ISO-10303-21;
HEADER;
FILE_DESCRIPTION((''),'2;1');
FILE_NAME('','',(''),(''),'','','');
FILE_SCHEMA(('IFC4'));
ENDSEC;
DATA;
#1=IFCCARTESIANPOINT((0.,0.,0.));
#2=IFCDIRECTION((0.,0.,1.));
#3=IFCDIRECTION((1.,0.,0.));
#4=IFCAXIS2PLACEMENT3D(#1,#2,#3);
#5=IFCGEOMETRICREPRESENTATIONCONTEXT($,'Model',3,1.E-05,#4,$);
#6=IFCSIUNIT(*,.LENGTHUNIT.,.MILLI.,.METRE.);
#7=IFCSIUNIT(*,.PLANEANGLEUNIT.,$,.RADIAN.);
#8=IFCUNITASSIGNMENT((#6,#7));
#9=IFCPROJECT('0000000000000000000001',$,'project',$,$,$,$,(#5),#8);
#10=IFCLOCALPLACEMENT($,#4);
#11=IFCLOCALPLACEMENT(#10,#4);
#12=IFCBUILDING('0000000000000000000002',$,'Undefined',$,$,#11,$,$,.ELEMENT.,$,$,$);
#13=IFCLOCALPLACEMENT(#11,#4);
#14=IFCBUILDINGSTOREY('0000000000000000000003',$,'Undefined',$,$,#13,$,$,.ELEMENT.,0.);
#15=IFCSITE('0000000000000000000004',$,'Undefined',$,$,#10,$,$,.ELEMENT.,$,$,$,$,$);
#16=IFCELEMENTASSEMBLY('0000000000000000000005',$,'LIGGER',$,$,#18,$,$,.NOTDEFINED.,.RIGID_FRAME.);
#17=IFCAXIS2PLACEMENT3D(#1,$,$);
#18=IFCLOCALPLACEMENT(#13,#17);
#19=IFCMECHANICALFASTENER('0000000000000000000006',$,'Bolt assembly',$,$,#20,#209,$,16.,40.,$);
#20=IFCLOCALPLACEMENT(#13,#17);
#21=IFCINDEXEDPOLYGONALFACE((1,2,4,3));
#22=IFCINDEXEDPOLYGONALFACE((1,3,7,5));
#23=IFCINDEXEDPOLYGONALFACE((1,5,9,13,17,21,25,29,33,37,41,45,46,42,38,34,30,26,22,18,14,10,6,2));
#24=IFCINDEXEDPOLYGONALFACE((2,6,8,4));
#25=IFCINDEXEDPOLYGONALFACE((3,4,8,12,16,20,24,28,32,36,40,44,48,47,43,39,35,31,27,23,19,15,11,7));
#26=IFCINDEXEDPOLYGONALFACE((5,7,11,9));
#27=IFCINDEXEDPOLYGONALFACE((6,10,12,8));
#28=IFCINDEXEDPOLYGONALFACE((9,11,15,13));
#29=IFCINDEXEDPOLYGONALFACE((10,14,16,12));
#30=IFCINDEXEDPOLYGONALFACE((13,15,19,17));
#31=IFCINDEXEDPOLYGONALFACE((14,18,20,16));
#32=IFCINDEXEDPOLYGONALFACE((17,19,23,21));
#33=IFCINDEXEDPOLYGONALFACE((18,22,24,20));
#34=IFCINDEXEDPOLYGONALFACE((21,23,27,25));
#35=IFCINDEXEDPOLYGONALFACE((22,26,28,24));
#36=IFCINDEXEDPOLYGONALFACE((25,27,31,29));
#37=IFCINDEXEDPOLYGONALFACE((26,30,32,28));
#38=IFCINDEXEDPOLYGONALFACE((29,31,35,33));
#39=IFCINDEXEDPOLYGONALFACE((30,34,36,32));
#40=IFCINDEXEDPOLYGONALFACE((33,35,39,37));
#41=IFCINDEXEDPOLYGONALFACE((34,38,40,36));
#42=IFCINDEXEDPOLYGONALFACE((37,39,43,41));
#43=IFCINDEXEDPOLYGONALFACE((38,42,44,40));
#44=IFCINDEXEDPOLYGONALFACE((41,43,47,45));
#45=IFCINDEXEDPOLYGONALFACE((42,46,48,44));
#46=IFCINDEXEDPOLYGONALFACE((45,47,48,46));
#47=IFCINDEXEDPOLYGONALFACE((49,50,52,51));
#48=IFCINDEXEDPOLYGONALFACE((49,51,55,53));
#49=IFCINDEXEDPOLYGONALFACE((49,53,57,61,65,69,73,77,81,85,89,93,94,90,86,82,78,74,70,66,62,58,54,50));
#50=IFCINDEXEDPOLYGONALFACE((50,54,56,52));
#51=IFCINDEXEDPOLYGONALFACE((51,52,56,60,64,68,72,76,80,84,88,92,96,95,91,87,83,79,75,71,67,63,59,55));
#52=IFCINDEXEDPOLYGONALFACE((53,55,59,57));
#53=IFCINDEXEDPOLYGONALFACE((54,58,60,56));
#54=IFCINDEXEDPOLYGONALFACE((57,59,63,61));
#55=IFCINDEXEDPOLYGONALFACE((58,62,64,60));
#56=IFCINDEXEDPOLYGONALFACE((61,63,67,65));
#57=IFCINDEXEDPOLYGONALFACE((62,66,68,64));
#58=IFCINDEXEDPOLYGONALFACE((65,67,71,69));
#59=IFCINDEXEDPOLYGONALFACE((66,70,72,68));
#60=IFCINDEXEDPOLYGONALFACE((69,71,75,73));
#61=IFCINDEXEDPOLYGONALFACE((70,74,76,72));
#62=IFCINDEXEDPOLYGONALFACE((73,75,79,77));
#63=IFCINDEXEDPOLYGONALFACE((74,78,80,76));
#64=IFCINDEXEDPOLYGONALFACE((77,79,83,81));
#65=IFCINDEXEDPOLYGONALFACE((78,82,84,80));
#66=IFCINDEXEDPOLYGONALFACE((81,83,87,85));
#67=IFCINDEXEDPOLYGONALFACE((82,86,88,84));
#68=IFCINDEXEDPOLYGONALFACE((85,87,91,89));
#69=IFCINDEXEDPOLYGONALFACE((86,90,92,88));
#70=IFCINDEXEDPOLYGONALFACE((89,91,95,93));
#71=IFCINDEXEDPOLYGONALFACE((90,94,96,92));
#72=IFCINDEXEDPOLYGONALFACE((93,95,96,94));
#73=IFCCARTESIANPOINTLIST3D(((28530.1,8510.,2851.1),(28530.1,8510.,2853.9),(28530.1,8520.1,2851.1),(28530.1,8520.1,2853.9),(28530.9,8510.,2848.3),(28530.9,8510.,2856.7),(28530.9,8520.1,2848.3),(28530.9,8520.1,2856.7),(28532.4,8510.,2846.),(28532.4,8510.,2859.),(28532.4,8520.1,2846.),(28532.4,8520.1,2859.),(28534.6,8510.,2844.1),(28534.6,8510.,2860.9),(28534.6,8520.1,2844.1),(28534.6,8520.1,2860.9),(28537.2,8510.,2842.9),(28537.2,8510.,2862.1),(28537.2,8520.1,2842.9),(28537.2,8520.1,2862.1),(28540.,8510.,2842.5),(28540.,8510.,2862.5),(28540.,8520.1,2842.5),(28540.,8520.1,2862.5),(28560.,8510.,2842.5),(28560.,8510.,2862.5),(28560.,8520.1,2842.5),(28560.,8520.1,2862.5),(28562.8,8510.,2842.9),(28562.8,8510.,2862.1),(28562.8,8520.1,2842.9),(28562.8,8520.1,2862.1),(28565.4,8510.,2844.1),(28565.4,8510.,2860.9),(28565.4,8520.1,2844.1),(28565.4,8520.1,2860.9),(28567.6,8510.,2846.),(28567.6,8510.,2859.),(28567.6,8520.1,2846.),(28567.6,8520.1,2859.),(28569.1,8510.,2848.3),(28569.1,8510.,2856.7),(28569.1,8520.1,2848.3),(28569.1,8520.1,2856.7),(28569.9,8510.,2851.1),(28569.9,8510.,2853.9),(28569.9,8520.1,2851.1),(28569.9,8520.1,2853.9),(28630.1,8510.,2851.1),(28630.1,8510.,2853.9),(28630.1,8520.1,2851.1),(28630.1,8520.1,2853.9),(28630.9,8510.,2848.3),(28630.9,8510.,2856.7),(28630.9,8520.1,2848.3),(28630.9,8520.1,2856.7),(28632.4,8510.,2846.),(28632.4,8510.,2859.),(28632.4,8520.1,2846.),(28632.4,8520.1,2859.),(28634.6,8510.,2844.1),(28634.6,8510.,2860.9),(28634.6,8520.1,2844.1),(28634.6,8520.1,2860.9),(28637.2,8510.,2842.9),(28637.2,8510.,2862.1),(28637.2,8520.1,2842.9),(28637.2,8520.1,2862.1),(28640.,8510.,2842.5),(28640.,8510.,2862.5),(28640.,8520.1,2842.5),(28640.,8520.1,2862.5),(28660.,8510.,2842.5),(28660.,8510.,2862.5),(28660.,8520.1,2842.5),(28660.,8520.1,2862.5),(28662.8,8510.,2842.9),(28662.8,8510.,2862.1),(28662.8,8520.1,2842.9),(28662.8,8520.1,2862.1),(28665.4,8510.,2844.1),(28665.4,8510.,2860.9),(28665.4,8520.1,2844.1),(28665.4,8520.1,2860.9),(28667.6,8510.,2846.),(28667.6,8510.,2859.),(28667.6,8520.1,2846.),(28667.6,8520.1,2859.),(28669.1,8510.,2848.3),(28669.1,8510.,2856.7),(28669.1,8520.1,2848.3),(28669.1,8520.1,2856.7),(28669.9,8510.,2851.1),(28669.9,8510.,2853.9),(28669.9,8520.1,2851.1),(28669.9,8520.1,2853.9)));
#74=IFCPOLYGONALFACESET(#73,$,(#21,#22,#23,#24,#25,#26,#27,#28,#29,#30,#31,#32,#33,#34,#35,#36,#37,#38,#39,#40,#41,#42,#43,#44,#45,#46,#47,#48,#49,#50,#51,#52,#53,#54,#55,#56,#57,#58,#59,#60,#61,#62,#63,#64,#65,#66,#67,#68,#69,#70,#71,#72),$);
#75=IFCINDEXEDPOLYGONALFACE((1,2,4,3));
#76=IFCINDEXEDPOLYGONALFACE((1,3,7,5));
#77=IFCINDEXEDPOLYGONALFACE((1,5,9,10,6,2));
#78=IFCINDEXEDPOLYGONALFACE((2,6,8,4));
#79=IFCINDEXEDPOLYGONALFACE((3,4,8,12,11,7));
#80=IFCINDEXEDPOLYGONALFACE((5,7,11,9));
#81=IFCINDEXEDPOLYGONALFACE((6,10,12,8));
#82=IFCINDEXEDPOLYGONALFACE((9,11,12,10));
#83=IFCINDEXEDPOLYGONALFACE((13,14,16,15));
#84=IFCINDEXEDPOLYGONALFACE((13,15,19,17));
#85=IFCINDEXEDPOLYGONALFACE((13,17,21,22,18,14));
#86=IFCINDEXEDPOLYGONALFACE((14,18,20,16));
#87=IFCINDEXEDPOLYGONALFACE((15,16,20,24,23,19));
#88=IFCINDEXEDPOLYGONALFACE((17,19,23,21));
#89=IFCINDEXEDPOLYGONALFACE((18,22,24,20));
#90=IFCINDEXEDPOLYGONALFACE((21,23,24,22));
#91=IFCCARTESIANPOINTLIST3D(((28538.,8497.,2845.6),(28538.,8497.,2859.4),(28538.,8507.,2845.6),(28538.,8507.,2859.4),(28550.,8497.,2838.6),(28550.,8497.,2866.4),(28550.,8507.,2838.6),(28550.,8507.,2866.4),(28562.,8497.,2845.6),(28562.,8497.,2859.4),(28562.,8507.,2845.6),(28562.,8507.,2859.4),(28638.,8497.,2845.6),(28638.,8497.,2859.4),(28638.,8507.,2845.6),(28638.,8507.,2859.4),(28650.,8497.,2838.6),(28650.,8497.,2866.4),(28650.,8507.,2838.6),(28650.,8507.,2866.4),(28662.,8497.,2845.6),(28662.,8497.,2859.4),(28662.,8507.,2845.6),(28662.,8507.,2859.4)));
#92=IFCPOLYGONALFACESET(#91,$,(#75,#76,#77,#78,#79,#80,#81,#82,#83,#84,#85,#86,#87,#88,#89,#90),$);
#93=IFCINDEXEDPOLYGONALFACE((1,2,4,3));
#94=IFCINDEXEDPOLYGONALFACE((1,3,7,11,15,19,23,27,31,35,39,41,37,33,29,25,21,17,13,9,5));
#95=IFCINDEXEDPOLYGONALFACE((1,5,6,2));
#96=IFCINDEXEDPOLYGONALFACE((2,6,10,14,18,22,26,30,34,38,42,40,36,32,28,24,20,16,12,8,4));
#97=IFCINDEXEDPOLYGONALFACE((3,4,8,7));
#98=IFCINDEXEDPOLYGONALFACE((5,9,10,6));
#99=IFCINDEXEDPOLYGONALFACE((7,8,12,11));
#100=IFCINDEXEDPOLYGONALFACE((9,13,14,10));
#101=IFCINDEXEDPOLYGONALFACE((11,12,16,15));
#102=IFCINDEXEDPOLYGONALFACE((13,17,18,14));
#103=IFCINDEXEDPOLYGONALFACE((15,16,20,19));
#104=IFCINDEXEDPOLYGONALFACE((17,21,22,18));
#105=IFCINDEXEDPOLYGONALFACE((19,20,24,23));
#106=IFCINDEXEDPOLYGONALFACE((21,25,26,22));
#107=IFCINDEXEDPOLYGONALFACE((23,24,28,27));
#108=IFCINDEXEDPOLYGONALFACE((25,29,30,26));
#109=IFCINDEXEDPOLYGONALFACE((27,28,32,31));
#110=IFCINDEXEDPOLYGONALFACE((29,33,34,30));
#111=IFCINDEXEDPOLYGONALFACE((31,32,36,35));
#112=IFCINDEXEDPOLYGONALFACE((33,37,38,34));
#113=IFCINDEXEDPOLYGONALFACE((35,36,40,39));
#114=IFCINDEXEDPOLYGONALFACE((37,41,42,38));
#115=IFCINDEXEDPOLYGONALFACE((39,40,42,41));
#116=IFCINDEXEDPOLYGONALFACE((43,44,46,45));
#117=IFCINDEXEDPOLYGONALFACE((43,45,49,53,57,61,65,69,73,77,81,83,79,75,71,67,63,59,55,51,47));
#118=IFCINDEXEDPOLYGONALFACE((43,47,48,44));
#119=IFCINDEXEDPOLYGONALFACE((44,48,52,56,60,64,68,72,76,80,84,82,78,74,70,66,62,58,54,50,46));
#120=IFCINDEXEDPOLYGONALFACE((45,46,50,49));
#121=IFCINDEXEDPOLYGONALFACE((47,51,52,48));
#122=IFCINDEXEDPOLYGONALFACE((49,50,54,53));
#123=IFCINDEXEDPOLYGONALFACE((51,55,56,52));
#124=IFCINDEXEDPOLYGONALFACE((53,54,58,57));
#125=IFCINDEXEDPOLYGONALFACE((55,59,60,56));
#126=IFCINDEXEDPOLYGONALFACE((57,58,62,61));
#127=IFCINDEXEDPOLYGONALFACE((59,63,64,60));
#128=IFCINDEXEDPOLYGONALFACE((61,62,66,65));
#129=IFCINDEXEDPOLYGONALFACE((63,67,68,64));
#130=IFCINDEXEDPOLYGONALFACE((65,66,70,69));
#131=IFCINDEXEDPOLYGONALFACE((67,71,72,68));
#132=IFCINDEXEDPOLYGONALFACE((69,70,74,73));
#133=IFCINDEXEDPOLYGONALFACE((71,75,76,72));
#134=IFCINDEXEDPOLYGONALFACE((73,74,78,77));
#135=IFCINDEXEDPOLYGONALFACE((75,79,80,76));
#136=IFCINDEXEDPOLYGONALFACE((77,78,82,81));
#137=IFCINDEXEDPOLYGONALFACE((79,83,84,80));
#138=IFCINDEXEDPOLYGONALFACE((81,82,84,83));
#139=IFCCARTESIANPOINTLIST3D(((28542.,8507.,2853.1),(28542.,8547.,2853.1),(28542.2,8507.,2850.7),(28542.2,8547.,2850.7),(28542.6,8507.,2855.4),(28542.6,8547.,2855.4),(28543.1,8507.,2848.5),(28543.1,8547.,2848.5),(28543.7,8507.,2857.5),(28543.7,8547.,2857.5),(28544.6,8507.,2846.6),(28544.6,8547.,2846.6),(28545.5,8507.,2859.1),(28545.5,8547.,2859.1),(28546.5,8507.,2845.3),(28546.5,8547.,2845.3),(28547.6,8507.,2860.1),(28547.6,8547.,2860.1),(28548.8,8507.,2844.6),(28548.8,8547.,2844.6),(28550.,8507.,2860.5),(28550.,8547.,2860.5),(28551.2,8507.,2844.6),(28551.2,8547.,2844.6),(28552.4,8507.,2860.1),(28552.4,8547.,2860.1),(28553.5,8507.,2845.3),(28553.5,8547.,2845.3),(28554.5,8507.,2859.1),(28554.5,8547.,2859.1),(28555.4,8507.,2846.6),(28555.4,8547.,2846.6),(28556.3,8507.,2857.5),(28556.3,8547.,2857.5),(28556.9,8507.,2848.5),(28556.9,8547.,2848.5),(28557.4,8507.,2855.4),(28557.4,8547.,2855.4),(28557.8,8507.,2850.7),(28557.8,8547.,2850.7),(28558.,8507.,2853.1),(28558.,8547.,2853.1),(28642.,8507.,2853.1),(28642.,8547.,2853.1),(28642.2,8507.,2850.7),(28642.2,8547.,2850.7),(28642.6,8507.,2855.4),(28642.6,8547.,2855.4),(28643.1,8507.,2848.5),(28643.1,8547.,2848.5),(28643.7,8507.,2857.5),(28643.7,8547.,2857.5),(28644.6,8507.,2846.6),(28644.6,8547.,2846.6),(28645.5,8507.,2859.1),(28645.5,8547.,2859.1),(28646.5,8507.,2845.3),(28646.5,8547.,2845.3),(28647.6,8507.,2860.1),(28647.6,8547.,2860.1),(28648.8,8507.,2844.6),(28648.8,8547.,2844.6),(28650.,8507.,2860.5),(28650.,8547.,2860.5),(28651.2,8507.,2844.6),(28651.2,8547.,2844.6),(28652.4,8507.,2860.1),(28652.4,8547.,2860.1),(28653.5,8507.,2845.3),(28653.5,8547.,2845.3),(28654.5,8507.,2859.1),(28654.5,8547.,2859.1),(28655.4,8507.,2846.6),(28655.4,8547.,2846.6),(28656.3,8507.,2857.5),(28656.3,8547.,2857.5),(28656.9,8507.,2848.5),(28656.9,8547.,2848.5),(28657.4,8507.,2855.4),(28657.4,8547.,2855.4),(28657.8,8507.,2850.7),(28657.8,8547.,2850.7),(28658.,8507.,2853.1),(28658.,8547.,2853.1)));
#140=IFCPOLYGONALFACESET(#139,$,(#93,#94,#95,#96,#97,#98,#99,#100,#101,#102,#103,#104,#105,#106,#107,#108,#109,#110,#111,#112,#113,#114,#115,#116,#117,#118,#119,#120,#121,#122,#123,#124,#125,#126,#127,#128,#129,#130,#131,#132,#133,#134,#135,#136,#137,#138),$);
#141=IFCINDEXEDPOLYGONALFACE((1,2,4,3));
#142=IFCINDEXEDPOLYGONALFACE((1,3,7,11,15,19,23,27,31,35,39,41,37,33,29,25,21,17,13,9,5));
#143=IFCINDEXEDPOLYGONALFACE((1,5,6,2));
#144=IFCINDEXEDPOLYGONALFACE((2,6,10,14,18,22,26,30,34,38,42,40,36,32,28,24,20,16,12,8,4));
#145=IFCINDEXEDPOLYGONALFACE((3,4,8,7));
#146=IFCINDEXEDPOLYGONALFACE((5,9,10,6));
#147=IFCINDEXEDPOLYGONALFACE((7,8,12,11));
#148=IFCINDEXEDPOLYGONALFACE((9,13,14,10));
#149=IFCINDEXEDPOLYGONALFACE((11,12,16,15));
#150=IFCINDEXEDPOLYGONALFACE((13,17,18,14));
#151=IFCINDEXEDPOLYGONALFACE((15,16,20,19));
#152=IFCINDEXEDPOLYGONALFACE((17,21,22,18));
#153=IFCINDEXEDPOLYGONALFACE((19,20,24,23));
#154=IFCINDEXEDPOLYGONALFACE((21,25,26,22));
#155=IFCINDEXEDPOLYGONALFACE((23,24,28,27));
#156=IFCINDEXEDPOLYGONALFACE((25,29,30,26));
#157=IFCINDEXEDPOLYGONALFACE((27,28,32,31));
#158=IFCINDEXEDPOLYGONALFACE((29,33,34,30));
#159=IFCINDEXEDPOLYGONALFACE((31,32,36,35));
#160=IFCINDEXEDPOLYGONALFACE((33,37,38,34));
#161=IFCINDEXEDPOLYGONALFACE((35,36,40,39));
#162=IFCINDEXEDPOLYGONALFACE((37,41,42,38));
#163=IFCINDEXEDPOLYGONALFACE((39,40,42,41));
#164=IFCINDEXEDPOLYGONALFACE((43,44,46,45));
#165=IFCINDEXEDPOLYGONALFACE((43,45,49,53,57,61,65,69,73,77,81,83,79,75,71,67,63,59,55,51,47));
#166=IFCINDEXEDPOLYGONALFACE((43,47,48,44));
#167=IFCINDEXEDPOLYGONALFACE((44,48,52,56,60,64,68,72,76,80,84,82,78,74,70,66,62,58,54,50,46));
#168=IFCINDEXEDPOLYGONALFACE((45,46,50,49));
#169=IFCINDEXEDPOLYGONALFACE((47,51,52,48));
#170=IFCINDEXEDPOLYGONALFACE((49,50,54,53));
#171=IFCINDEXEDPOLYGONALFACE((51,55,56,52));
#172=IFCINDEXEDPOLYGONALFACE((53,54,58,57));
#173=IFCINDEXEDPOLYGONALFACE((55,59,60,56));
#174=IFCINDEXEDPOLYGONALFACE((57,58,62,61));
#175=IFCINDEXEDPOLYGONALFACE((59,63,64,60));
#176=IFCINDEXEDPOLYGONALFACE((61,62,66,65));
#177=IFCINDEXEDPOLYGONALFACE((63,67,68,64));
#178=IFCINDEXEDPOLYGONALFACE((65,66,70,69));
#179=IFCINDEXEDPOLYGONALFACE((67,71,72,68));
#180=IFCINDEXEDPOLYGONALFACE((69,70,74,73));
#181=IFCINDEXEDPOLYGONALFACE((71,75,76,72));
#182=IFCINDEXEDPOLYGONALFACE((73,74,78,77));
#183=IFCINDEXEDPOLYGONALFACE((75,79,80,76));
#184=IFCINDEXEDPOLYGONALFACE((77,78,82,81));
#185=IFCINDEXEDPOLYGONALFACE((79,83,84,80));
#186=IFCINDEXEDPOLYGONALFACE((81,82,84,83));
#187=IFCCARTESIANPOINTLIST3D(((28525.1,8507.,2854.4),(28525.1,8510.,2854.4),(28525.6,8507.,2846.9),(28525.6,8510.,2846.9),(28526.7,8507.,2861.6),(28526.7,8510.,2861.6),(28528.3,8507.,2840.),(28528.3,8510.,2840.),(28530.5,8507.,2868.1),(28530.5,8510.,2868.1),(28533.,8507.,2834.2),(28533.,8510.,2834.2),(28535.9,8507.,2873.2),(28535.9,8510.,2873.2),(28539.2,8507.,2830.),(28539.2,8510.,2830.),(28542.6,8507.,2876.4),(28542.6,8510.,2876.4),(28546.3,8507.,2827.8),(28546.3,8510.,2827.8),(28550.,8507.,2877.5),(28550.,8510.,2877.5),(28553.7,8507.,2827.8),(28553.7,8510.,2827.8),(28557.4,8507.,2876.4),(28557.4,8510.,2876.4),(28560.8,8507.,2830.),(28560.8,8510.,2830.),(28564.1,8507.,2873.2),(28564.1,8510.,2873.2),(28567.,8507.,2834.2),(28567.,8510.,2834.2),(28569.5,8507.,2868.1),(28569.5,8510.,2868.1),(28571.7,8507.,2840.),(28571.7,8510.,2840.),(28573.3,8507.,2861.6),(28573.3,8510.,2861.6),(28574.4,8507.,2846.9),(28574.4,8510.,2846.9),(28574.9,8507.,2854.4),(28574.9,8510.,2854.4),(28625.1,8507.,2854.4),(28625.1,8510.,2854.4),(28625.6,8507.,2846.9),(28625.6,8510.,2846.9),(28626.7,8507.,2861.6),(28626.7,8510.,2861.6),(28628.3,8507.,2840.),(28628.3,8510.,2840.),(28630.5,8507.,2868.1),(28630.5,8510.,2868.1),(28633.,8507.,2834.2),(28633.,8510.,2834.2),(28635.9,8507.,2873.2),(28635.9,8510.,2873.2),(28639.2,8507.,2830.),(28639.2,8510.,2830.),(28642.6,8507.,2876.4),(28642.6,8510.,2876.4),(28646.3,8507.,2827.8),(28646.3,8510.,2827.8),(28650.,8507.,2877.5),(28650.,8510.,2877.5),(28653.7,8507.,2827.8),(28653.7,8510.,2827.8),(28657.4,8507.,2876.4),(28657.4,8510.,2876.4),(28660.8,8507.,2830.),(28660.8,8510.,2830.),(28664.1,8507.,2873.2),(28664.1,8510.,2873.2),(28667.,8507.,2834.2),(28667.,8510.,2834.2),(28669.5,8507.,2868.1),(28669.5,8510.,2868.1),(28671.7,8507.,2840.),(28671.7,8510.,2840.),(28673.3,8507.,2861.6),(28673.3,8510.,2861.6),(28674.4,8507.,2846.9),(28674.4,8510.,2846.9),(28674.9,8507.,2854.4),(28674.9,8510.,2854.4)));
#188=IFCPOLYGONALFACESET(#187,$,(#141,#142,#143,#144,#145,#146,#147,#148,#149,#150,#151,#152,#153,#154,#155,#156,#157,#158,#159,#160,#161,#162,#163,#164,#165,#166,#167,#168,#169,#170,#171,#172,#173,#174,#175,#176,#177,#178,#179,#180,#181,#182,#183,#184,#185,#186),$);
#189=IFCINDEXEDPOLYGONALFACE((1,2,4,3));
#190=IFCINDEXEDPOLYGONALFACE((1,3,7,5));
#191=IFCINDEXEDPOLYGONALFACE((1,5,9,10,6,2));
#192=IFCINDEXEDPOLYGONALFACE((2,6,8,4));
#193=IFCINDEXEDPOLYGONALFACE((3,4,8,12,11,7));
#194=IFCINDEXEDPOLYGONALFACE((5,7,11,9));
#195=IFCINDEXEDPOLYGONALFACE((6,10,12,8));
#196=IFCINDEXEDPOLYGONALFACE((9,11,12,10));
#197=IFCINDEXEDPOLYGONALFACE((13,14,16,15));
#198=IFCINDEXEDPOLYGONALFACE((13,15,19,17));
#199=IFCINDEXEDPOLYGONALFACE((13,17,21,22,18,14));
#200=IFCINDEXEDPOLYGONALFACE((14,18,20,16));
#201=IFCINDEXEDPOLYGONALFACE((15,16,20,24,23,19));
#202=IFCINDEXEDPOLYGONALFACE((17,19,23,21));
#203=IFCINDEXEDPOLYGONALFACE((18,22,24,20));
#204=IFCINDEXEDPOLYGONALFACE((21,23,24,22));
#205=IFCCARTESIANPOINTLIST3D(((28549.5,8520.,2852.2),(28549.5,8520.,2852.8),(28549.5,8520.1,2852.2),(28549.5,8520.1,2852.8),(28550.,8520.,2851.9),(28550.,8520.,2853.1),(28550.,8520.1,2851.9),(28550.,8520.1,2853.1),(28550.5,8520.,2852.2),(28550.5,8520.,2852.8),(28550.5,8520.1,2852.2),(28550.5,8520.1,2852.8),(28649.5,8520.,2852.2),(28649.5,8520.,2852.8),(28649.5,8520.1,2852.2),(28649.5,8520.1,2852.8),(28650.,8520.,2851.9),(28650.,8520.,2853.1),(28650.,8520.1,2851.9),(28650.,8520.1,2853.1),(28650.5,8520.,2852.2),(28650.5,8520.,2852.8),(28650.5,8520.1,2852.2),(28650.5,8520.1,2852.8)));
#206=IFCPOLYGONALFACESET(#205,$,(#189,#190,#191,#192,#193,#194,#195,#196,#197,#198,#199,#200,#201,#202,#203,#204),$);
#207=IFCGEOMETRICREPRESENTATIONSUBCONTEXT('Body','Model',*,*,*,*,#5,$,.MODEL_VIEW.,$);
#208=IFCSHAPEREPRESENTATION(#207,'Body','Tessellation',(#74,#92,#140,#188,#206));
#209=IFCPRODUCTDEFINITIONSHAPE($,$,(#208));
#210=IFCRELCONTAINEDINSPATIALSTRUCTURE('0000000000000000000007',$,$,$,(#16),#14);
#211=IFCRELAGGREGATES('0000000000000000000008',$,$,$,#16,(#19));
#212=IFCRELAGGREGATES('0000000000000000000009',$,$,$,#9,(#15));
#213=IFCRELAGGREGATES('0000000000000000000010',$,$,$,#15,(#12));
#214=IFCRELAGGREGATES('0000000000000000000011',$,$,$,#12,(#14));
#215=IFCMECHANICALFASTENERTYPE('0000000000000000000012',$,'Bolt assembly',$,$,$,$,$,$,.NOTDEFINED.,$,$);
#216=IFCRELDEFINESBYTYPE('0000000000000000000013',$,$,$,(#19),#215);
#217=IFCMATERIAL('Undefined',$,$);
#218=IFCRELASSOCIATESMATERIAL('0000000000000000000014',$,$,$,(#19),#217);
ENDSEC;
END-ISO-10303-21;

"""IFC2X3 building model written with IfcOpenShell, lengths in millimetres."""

from ifc_helpers import new_model, si_unit, frame, frame_2d, origin_with_axes, origin_2d_with_axis, place, context, subcontext, project, spatial, polyline, circle_curve, parameter, trimmed, segment, composite_curve, circle, outline, extrude, source, transform, mapped, material, type_object, element, aggregate, save


model = new_model("IFC2X3")

# Units and contexts
model_context = context("Model", 3, precision=1e-05, world=origin_with_axes())
body_context = subcontext(model_context, "Body", "Model", "MODEL_VIEW")
ifc_project = project(units=[si_unit("LENGTHUNIT", "METRE", prefix="MILLI"), si_unit("PLANEANGLEUNIT", "RADIAN")], contexts=[model_context])

# Site, building, storey
site_placement = place(None, origin_with_axes())
site = spatial("IfcSite", under=ifc_project, at=site_placement, Name="Undefined", CompositionType="ELEMENT")
building_placement = place(site_placement, origin_with_axes())
building = spatial("IfcBuilding", under=site, at=building_placement, Name="Undefined", CompositionType="ELEMENT")
storey_placement = place(building_placement, origin_with_axes())
storey = spatial("IfcBuildingStorey", under=building, at=storey_placement, Name="Undefined", CompositionType="ELEMENT", Elevation=0.0)

# Element assembly
assembly_1_placement = place(storey_placement, origin_with_axes())
assembly_1 = element("IfcElementAssembly", 1, at=assembly_1_placement, inside=storey, Name="LIGGER", AssemblyPlace="NOTDEFINED", PredefinedType="RIGID_FRAME")

# Mechanical fastener
ifc_material_1 = material(Name="Undefined")
mechanical_fastener_type = type_object("IfcMechanicalFastenerType", Name="Bolt assembly")
shared_shape_1 = source(origin_with_axes(), body_context, "Body", "SweptSolid", [
    extrude(outline(composite_curve([segment(polyline([(10.0, 10.0), (10.0, -10.0)]), True, "CONTINUOUS"), segment(trimmed(circle_curve(frame_2d((0.0, -10.0), x_axis=(1.0, 0.0)), 10.0), [parameter(0.0)], [parameter(3.141593)], False, "PARAMETER"), True, "CONTINUOUS"), segment(polyline([(-10.0, -10.0), (-10.0, 10.0)]), True, "CONTINUOUS"), segment(trimmed(circle_curve(frame_2d((0.0, 10.0), x_axis=(-1.0, 0.0)), 10.0), [parameter(0.0)], [parameter(3.141593)], False, "PARAMETER"), True, "DISCONTINUOUS")], self_intersect=False)), frame((0.0, 30.0, 0.0), z_axis=(0.0, 1.0, 0.0), x_axis=(1.0, 0.0, 0.0)), (0.0, 0.0, 1.0), 10.1),
    extrude(outline(polyline([(13.9, 0.0), (6.9, 12.0), (-6.9, 12.0), (-13.9, 0.0), (-6.9, -12.0), (6.9, -12.0), (13.9, 0.0)])), frame((0.0, 17.0, 0.0), z_axis=(0.0, 1.0, 0.0), x_axis=(1.0, 0.0, 0.0)), (0.0, 0.0, 1.0), 10.0),
    extrude(circle(Radius=8.0, at=origin_2d_with_axis()), frame((0.0, 27.0, 0.0), z_axis=(0.0, 1.0, 0.0), x_axis=(1.0, 0.0, 0.0)), (0.0, 0.0, 1.0), 40.0),
    extrude(circle(Radius=25.0, at=origin_2d_with_axis()), frame((0.0, 27.0, 0.0), z_axis=(0.0, 1.0, 0.0), x_axis=(1.0, 0.0, 0.0)), (0.0, 0.0, 1.0), 3.0),
    extrude(outline(polyline([(0.6, 0.0), (0.3, 0.5), (-0.3, 0.5), (-0.6, 0.0), (-0.3, -0.5), (0.3, -0.5), (0.6, 0.0)])), frame((0.0, 40.0, 0.0), z_axis=(0.0, 1.0, 0.0), x_axis=(1.0, 0.0, 0.0)), (0.0, 0.0, 1.0), 0.1),
])
mechanical_fastener_1_placement = place(assembly_1_placement, frame((28600.0, 8480.0, 2852.5), z_axis=(-1.0, 0.0, 0.0), x_axis=(0.0, 0.0, 1.0)))
mechanical_fastener_1 = element("IfcMechanicalFastener", 2, at=mechanical_fastener_1_placement, type_object=mechanical_fastener_type, material=ifc_material_1, Name="Bolt assembly", NominalDiameter=16.0, NominalLength=40.0, context=body_context, shape_type="MappedRepresentation", body=[
    mapped(shared_shape_1, transform((0.0, 0.0, -50.0))),
    mapped(shared_shape_1, transform((0.0, 0.0, 50.0))),
])
aggregate(assembly_1, [mechanical_fastener_1])

save(model, "model.ifc")
